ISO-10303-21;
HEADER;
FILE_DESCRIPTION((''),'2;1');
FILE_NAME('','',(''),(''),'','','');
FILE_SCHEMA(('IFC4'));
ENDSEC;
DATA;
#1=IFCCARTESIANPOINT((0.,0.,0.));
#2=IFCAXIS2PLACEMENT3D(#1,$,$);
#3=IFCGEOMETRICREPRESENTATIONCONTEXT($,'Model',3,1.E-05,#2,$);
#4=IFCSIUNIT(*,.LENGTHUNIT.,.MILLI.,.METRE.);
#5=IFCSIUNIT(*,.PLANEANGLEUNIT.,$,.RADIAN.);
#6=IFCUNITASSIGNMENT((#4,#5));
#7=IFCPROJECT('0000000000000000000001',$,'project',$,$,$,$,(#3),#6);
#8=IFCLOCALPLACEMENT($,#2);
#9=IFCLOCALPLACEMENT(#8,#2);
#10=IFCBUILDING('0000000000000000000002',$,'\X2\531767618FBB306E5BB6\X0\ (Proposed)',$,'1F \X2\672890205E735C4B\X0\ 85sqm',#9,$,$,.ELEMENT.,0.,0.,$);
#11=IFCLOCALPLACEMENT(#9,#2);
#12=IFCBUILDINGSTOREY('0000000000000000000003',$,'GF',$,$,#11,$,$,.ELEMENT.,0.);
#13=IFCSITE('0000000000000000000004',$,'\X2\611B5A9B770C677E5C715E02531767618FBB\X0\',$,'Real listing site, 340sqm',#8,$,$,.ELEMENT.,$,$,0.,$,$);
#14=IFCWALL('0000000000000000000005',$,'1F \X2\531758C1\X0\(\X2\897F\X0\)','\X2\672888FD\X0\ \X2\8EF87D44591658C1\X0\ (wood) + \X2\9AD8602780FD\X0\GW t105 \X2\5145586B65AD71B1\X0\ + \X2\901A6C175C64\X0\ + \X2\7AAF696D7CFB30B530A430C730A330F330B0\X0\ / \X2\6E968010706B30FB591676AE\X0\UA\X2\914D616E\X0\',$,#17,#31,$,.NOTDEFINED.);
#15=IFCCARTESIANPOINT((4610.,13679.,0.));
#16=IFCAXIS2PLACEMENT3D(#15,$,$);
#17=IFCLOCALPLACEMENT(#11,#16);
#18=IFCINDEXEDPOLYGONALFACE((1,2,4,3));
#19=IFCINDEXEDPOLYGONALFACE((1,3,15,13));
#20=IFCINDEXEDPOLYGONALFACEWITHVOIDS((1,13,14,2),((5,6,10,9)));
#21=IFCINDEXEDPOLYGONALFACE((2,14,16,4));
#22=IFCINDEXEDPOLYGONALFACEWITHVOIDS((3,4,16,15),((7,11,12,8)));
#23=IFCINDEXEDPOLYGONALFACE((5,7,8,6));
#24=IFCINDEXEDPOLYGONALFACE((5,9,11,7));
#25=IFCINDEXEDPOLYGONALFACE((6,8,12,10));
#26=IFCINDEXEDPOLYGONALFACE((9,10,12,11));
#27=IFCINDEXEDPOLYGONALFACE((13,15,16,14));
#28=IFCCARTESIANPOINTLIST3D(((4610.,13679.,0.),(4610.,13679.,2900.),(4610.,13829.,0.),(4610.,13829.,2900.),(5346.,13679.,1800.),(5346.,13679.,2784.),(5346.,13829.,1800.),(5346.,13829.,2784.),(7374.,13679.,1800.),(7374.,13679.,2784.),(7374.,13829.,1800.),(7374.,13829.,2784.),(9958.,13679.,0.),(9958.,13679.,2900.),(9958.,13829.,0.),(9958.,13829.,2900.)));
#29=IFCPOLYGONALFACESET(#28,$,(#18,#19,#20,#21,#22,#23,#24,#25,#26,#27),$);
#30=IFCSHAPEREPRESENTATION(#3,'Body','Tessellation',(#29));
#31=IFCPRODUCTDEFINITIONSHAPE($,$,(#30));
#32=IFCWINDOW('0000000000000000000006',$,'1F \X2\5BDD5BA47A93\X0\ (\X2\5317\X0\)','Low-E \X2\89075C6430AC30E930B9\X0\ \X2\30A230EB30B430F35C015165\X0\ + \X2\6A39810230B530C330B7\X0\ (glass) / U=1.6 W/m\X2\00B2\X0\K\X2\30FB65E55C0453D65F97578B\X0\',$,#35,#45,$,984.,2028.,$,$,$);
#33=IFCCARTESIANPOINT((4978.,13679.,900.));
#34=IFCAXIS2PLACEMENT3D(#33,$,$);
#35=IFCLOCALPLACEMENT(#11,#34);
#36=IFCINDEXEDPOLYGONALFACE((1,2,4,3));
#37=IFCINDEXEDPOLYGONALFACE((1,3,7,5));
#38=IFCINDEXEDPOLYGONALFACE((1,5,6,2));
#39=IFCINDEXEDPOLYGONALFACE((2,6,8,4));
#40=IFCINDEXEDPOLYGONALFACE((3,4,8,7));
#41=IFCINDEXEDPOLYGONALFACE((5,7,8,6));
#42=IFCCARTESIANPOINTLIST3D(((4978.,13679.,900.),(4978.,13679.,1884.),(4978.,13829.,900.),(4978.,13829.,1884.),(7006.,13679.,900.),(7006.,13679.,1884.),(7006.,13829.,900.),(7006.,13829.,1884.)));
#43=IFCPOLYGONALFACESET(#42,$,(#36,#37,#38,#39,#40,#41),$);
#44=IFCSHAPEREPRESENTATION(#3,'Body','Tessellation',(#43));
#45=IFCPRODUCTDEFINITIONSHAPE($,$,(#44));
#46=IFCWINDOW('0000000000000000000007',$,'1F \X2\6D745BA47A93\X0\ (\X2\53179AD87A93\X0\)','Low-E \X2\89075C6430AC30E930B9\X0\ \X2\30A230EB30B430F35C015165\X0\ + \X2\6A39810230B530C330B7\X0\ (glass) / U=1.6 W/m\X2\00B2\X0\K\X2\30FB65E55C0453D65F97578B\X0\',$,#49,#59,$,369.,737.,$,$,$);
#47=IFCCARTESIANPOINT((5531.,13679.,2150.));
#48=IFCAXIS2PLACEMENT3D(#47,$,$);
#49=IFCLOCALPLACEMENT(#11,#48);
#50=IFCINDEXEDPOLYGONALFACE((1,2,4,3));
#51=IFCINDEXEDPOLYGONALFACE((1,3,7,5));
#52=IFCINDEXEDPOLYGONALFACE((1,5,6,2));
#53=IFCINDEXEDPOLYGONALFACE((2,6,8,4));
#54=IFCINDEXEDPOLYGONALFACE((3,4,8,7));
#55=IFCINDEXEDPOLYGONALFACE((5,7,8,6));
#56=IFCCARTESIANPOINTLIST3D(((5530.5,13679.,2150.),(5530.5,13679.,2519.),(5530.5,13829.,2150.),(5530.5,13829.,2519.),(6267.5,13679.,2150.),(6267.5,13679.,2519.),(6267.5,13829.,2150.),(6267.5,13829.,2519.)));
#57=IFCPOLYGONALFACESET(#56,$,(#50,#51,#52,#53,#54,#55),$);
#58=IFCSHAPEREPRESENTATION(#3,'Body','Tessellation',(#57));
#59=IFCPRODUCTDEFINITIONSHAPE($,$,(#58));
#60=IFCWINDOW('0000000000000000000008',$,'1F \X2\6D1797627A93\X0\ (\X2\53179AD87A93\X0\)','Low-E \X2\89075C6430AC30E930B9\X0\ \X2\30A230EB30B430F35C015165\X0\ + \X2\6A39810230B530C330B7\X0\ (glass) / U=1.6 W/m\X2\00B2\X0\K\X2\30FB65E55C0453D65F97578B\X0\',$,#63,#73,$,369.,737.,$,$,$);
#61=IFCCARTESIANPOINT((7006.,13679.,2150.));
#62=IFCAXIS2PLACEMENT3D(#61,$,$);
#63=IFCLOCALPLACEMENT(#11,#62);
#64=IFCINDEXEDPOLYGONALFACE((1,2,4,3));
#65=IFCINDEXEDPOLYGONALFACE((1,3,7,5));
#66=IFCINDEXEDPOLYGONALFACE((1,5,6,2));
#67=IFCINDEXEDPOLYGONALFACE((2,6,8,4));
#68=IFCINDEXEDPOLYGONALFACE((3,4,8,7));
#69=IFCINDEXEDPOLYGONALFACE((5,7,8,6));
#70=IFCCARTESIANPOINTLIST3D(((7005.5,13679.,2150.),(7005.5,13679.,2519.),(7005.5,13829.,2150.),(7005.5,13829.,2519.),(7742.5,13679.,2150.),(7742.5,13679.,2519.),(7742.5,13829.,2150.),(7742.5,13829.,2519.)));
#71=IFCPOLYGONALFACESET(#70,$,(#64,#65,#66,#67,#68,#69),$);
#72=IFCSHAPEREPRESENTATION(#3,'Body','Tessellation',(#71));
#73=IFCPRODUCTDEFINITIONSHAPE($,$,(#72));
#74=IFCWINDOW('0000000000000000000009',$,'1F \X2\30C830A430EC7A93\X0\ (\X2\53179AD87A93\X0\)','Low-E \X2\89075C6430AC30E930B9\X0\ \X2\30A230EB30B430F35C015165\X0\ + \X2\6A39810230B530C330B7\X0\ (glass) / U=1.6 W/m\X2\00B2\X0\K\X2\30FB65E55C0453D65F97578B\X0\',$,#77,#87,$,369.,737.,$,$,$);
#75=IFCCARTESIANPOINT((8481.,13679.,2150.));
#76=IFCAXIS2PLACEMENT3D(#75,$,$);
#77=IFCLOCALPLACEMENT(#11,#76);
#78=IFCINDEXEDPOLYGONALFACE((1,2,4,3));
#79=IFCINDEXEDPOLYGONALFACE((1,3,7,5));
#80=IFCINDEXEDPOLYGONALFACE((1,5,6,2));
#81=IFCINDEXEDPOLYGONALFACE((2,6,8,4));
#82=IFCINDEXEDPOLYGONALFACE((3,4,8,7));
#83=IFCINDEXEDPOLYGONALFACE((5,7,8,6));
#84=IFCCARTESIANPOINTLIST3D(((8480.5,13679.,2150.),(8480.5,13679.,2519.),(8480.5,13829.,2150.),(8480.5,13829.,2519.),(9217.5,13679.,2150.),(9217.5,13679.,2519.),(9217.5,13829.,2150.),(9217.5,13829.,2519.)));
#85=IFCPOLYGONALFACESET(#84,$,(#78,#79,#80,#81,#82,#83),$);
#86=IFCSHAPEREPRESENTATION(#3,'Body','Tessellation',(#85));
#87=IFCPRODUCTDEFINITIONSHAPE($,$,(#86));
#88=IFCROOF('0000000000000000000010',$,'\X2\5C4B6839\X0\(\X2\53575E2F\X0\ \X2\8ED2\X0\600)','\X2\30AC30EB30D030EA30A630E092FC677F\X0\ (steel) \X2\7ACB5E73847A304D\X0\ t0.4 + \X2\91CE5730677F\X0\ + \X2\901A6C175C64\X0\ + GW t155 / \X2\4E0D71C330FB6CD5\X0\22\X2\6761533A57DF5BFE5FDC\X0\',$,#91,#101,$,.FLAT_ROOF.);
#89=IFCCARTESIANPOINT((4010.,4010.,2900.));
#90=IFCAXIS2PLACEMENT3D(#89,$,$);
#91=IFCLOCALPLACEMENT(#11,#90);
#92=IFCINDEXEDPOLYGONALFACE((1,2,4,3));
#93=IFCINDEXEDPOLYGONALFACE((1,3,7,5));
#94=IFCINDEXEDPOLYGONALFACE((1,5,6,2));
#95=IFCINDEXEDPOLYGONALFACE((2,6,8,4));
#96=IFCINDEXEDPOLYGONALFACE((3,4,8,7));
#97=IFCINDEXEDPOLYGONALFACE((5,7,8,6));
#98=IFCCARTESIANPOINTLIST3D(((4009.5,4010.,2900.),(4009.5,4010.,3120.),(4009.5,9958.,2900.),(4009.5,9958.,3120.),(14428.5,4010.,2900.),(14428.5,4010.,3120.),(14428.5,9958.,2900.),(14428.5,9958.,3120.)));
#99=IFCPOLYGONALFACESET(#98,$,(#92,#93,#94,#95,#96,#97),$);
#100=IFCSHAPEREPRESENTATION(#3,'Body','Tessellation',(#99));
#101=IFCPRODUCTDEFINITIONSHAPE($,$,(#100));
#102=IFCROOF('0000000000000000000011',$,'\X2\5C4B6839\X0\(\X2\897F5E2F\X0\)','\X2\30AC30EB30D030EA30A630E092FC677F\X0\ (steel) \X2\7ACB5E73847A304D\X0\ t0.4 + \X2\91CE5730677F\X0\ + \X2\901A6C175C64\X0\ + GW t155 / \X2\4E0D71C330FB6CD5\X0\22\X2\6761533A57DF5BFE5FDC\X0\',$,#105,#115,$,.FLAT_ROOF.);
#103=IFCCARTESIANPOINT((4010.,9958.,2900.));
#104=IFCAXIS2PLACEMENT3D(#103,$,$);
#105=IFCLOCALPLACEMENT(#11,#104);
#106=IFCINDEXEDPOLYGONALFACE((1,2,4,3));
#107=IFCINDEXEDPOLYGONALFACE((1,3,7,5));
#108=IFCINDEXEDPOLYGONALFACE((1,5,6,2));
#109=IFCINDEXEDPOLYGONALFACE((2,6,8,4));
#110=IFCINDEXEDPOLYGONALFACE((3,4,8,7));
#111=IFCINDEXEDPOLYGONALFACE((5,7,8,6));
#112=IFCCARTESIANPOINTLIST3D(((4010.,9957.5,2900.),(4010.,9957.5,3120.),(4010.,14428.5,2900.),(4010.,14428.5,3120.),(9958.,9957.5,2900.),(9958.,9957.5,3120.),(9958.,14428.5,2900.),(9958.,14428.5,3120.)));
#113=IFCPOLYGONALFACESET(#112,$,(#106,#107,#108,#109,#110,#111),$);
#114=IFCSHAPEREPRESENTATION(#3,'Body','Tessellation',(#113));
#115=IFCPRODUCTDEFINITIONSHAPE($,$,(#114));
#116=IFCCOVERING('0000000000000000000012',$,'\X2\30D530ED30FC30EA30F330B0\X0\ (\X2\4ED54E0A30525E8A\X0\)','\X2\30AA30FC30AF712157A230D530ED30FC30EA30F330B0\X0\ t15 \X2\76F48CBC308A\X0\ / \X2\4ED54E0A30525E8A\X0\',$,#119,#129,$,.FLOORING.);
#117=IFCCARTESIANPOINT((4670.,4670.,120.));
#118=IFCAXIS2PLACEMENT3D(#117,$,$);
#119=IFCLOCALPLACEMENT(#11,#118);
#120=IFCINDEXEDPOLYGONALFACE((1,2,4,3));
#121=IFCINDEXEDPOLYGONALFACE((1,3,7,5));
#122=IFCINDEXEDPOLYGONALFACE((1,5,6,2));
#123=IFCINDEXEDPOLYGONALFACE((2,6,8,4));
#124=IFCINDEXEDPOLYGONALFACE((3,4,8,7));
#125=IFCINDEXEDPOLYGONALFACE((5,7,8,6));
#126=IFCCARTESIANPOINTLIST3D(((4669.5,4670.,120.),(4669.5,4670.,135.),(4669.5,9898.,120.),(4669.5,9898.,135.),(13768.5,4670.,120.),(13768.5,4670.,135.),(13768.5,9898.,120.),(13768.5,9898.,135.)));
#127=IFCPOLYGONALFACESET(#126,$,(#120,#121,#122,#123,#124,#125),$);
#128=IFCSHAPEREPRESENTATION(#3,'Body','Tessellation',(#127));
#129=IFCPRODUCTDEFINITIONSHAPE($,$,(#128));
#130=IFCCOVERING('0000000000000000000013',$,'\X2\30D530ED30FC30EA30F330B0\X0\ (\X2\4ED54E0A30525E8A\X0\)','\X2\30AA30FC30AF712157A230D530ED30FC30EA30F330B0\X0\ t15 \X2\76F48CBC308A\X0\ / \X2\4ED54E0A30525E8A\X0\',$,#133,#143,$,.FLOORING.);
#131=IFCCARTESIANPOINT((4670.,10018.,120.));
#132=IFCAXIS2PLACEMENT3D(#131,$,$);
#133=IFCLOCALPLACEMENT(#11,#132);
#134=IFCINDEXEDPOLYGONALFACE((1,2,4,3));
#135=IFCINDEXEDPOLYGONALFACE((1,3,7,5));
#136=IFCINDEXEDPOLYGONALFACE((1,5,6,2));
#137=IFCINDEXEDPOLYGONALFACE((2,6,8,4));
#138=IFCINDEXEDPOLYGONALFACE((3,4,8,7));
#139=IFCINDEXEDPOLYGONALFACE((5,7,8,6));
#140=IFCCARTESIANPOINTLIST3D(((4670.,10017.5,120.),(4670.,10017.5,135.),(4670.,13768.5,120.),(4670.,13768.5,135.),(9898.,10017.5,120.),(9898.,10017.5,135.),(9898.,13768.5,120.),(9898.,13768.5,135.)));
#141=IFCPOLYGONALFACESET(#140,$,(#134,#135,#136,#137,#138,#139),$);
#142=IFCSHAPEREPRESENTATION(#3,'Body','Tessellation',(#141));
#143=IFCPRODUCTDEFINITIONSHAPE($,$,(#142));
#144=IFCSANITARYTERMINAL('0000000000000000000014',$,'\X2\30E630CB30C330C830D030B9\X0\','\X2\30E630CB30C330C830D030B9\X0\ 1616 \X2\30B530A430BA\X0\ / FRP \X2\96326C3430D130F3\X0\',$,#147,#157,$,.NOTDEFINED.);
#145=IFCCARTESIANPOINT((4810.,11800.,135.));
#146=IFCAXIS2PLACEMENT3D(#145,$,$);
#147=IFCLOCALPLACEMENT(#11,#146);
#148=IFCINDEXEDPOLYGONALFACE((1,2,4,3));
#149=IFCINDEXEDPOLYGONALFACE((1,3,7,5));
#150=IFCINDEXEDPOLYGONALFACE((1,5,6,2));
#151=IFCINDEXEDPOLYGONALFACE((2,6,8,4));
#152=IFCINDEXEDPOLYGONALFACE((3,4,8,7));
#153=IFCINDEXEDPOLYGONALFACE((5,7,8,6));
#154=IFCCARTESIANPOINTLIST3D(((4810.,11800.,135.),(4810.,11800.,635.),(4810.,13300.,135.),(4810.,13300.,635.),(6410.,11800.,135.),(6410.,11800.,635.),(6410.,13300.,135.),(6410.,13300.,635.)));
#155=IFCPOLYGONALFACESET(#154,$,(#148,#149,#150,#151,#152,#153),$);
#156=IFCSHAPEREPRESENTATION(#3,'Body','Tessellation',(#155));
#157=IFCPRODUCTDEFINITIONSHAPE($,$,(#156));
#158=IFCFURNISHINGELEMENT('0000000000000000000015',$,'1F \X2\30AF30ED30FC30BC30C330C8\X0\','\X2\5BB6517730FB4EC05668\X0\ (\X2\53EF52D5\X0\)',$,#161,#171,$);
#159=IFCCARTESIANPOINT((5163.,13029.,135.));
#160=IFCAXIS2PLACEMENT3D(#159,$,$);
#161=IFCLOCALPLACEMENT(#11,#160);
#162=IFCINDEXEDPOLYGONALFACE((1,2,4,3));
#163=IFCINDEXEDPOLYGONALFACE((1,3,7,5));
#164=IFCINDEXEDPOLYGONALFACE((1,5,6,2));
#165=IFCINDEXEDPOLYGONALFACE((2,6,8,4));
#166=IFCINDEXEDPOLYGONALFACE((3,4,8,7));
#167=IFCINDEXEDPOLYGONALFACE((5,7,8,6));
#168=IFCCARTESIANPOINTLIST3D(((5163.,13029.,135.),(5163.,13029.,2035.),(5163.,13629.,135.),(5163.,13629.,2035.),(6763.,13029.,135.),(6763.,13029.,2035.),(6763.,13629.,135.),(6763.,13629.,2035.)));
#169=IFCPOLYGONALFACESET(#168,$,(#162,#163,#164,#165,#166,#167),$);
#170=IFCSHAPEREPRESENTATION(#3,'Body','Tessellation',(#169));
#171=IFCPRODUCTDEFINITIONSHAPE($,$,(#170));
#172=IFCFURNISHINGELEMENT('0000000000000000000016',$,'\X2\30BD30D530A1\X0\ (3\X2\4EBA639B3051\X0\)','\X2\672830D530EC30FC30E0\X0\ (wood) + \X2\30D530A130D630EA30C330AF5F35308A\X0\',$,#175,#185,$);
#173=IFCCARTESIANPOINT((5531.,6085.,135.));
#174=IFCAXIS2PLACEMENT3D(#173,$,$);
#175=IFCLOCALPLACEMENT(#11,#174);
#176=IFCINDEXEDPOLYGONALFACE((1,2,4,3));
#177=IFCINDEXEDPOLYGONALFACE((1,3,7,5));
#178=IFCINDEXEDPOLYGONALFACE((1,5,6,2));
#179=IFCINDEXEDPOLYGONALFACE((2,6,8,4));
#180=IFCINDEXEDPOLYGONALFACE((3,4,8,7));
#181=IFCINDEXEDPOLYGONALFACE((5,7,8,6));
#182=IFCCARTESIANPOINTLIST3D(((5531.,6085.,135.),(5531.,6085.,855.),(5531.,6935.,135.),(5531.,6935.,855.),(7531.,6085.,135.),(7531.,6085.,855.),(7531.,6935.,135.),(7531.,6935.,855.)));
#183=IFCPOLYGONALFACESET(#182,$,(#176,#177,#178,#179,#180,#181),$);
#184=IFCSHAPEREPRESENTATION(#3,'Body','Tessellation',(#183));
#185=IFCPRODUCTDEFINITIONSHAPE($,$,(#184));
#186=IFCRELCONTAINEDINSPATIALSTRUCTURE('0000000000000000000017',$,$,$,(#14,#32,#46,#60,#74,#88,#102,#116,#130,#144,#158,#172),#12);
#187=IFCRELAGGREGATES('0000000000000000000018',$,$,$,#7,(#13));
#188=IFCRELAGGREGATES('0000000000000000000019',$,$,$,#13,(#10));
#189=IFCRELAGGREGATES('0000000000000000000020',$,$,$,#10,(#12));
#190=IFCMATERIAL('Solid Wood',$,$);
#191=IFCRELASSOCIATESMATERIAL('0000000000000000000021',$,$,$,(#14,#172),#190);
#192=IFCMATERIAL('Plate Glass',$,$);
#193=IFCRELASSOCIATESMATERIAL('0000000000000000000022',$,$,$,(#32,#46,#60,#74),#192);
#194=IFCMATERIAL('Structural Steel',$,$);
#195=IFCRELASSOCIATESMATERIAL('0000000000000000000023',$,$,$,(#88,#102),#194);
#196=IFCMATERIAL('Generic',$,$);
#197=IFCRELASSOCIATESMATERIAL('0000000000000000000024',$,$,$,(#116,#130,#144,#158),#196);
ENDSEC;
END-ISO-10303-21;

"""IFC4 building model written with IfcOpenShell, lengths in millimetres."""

from ifc_helpers import new_model, si_unit, frame, frame_2d, origin, place, context, project, spatial, rectangle, extrude, material, element, fill, save


model = new_model("IFC4")

# Units and contexts
model_context = context("Model", 3, precision=1e-05, world=origin())
ifc_project = project(units=[si_unit("LENGTHUNIT", "METRE", prefix="MILLI"), si_unit("PLANEANGLEUNIT", "RADIAN")], contexts=[model_context])

# Site, building, storey
site_placement = place(None, origin())
site = spatial("IfcSite", under=ifc_project, at=site_placement, Name="愛媛県松山市北条辻", ObjectType="Real listing site, 340sqm", CompositionType="ELEMENT", RefElevation=0.0)
building_placement = place(site_placement, origin())
building = spatial("IfcBuilding", under=site, at=building_placement, Name="北条辻の家 (Proposed)", ObjectType="1F 木造平屋 85sqm", CompositionType="ELEMENT", ElevationOfRefHeight=0.0, ElevationOfTerrain=0.0)
storey_placement = place(building_placement, origin())
storey = spatial("IfcBuildingStorey", under=building, at=storey_placement, Name="GF", CompositionType="ELEMENT", Elevation=0.0)

# Shared definitions
ifc_material_1 = material(Name="Solid Wood")

# Shared definitions
ifc_material_2 = material(Name="Plate Glass")

# Wall, openings, windows
wall_1_placement = place(storey_placement, frame((4610.0, 13679.0, 0.0)))
wall_1 = element("IfcWall", 1, at=wall_1_placement, inside=storey, material=ifc_material_1, Name="1F 北壁(西)", Description="木製 軸組外壁 (wood) + 高性能GW t105 充填断熱 + 通気層 + 窯業系サイディング / 準耐火・外皮UA配慮", PredefinedType="NOTDEFINED", context=model_context, shape_type="SweptSolid", body=[
    extrude(rectangle(XDim=5348.0, YDim=150.0, at=frame_2d((2674.0, 75.0))), frame((4610.0, 13679.0, 0.0)), (0.0, 0.0, 1.0), 2900.0),
])
opening_1_placement = place(storey_placement, frame((4978.0, 13679.0, 900.0)))
opening_1 = element("IfcOpeningElement", 2, at=opening_1_placement, cuts=wall_1, PredefinedType="NOTDEFINED", context=model_context, shape_type="SweptSolid", body=[
    extrude(rectangle(XDim=2028.0, YDim=150.0, at=frame_2d((1014.0, 75.0))), frame((4978.0, 13679.0, 900.0)), (0.0, 0.0, 1.0), 984.0),
])
opening_2_placement = place(storey_placement, frame((5531.0, 13679.0, 2150.0)))
opening_2 = element("IfcOpeningElement", 3, at=opening_2_placement, cuts=wall_1, PredefinedType="NOTDEFINED", context=model_context, shape_type="SweptSolid", body=[
    extrude(rectangle(XDim=737.0, YDim=150.0, at=frame_2d((368.0, 75.0))), frame((5531.0, 13679.0, 2150.0)), (0.0, 0.0, 1.0), 369.0),
])
opening_3_placement = place(storey_placement, frame((7006.0, 13679.0, 2150.0)))
opening_3 = element("IfcOpeningElement", 4, at=opening_3_placement, cuts=wall_1, PredefinedType="NOTDEFINED", context=model_context, shape_type="SweptSolid", body=[
    extrude(rectangle(XDim=737.0, YDim=150.0, at=frame_2d((368.0, 75.0))), frame((7006.0, 13679.0, 2150.0)), (0.0, 0.0, 1.0), 369.0),
])
opening_4_placement = place(storey_placement, frame((8481.0, 13679.0, 2150.0)))
opening_4 = element("IfcOpeningElement", 5, at=opening_4_placement, cuts=wall_1, PredefinedType="NOTDEFINED", context=model_context, shape_type="SweptSolid", body=[
    extrude(rectangle(XDim=737.0, YDim=150.0, at=frame_2d((368.0, 75.0))), frame((8481.0, 13679.0, 2150.0)), (0.0, 0.0, 1.0), 369.0),
])
window_1_placement = place(storey_placement, frame((4978.0, 13679.0, 900.0)))
window_1 = element("IfcWindow", 6, at=window_1_placement, inside=storey, material=ifc_material_2, Name="1F 寝室窓 (北)", Description="Low-E 複層ガラス アルゴン封入 + 樹脂サッシ (glass) / U=1.6 W/m²K・日射取得型", OverallHeight=984.0, OverallWidth=2028.0, context=model_context, shape_type="SweptSolid", body=[
    extrude(rectangle(XDim=2028.0, YDim=150.0, at=frame_2d((1014.0, 75.0))), frame((4978.0, 13679.0, 900.0)), (0.0, 0.0, 1.0), 984.0),
])
fill(opening_1, window_1)
window_2_placement = place(storey_placement, frame((5531.0, 13679.0, 2150.0)))
window_2 = element("IfcWindow", 7, at=window_2_placement, inside=storey, material=ifc_material_2, Name="1F 浴室窓 (北高窓)", Description="Low-E 複層ガラス アルゴン封入 + 樹脂サッシ (glass) / U=1.6 W/m²K・日射取得型", OverallHeight=369.0, OverallWidth=737.0, context=model_context, shape_type="SweptSolid", body=[
    extrude(rectangle(XDim=737.0, YDim=150.0, at=frame_2d((368.0, 75.0))), frame((5531.0, 13679.0, 2150.0)), (0.0, 0.0, 1.0), 369.0),
])
fill(opening_2, window_2)
window_3_placement = place(storey_placement, frame((7006.0, 13679.0, 2150.0)))
window_3 = element("IfcWindow", 8, at=window_3_placement, inside=storey, material=ifc_material_2, Name="1F 洗面窓 (北高窓)", Description="Low-E 複層ガラス アルゴン封入 + 樹脂サッシ (glass) / U=1.6 W/m²K・日射取得型", OverallHeight=369.0, OverallWidth=737.0, context=model_context, shape_type="SweptSolid", body=[
    extrude(rectangle(XDim=737.0, YDim=150.0, at=frame_2d((368.0, 75.0))), frame((7006.0, 13679.0, 2150.0)), (0.0, 0.0, 1.0), 369.0),
])
fill(opening_3, window_3)
window_4_placement = place(storey_placement, frame((8481.0, 13679.0, 2150.0)))
window_4 = element("IfcWindow", 9, at=window_4_placement, inside=storey, material=ifc_material_2, Name="1F トイレ窓 (北高窓)", Description="Low-E 複層ガラス アルゴン封入 + 樹脂サッシ (glass) / U=1.6 W/m²K・日射取得型", OverallHeight=369.0, OverallWidth=737.0, context=model_context, shape_type="SweptSolid", body=[
    extrude(rectangle(XDim=737.0, YDim=150.0, at=frame_2d((368.0, 75.0))), frame((8481.0, 13679.0, 2150.0)), (0.0, 0.0, 1.0), 369.0),
])
fill(opening_4, window_4)

# Roofs
ifc_material_3 = material(Name="Structural Steel")
roof_1_placement = place(storey_placement, frame((4010.0, 4010.0, 2900.0)))
element("IfcRoof", 10, at=roof_1_placement, inside=storey, material=ifc_material_3, Name="屋根(南帯 軒600)", Description="ガルバリウム鋼板 (steel) 立平葺き t0.4 + 野地板 + 通気層 + GW t155 / 不燃・法22条区域対応", PredefinedType="FLAT_ROOF", context=model_context, shape_type="SweptSolid", body=[
    extrude(rectangle(XDim=10419.0, YDim=5948.0, at=frame_2d((5209.0, 2974.0))), frame((4010.0, 4010.0, 2900.0)), (0.0, 0.0, 1.0), 220.0),
])
roof_2_placement = place(storey_placement, frame((4010.0, 9958.0, 2900.0)))
element("IfcRoof", 11, at=roof_2_placement, inside=storey, material=ifc_material_3, Name="屋根(西帯)", Description="ガルバリウム鋼板 (steel) 立平葺き t0.4 + 野地板 + 通気層 + GW t155 / 不燃・法22条区域対応", PredefinedType="FLAT_ROOF", context=model_context, shape_type="SweptSolid", body=[
    extrude(rectangle(XDim=5948.0, YDim=4471.0, at=frame_2d((2974.0, 2235.0))), frame((4010.0, 9958.0, 2900.0)), (0.0, 0.0, 1.0), 220.0),
])

# Coverings
ifc_material_4 = material(Name="Generic")
covering_1_placement = place(storey_placement, frame((4670.0, 4670.0, 120.0)))
element("IfcCovering", 12, at=covering_1_placement, inside=storey, material=ifc_material_4, Name="フローリング (仕上げ床)", Description="オーク無垢フローリング t15 直貼り / 仕上げ床", PredefinedType="FLOORING", context=model_context, shape_type="SweptSolid", body=[
    extrude(rectangle(XDim=9099.0, YDim=5228.0, at=frame_2d((4549.0, 2614.0))), frame((4670.0, 4670.0, 120.0)), (0.0, 0.0, 1.0), 15.0),
])
covering_2_placement = place(storey_placement, frame((4670.0, 10018.0, 120.0)))
element("IfcCovering", 13, at=covering_2_placement, inside=storey, material=ifc_material_4, Name="フローリング (仕上げ床)", Description="オーク無垢フローリング t15 直貼り / 仕上げ床", PredefinedType="FLOORING", context=model_context, shape_type="SweptSolid", body=[
    extrude(rectangle(XDim=5228.0, YDim=3751.0, at=frame_2d((2614.0, 1875.0))), frame((4670.0, 10018.0, 120.0)), (0.0, 0.0, 1.0), 15.0),
])

# Sanitary terminal
sanitary_terminal_placement = place(storey_placement, frame((4810.0, 11800.0, 135.0)))
element("IfcSanitaryTerminal", 14, at=sanitary_terminal_placement, inside=storey, material=ifc_material_4, Name="ユニットバス", Description="ユニットバス 1616 サイズ / FRP 防水パン", PredefinedType="NOTDEFINED", context=model_context, shape_type="SweptSolid", body=[
    extrude(rectangle(XDim=1600.0, YDim=1500.0, at=frame_2d((800.0, 750.0))), frame((4810.0, 11800.0, 135.0)), (0.0, 0.0, 1.0), 500.0),
])

# Furnishing elements
furnishing_1_placement = place(storey_placement, frame((5163.0, 13029.0, 135.0)))
element("IfcFurnishingElement", 15, at=furnishing_1_placement, inside=storey, material=ifc_material_4, Name="1F クローゼット", Description="家具・什器 (可動)", context=model_context, shape_type="SweptSolid", body=[
    extrude(rectangle(XDim=1600.0, YDim=600.0, at=frame_2d((800.0, 300.0))), frame((5163.0, 13029.0, 135.0)), (0.0, 0.0, 1.0), 1900.0),
])
furnishing_2_placement = place(storey_placement, frame((5531.0, 6085.0, 135.0)))
element("IfcFurnishingElement", 16, at=furnishing_2_placement, inside=storey, material=ifc_material_1, Name="ソファ (3人掛け)", Description="木フレーム (wood) + ファブリック張り", context=model_context, shape_type="SweptSolid", body=[
    extrude(rectangle(XDim=2000.0, YDim=850.0, at=frame_2d((1000.0, 425.0))), frame((5531.0, 6085.0, 135.0)), (0.0, 0.0, 1.0), 720.0),
])

save(model, "model.ifc")
